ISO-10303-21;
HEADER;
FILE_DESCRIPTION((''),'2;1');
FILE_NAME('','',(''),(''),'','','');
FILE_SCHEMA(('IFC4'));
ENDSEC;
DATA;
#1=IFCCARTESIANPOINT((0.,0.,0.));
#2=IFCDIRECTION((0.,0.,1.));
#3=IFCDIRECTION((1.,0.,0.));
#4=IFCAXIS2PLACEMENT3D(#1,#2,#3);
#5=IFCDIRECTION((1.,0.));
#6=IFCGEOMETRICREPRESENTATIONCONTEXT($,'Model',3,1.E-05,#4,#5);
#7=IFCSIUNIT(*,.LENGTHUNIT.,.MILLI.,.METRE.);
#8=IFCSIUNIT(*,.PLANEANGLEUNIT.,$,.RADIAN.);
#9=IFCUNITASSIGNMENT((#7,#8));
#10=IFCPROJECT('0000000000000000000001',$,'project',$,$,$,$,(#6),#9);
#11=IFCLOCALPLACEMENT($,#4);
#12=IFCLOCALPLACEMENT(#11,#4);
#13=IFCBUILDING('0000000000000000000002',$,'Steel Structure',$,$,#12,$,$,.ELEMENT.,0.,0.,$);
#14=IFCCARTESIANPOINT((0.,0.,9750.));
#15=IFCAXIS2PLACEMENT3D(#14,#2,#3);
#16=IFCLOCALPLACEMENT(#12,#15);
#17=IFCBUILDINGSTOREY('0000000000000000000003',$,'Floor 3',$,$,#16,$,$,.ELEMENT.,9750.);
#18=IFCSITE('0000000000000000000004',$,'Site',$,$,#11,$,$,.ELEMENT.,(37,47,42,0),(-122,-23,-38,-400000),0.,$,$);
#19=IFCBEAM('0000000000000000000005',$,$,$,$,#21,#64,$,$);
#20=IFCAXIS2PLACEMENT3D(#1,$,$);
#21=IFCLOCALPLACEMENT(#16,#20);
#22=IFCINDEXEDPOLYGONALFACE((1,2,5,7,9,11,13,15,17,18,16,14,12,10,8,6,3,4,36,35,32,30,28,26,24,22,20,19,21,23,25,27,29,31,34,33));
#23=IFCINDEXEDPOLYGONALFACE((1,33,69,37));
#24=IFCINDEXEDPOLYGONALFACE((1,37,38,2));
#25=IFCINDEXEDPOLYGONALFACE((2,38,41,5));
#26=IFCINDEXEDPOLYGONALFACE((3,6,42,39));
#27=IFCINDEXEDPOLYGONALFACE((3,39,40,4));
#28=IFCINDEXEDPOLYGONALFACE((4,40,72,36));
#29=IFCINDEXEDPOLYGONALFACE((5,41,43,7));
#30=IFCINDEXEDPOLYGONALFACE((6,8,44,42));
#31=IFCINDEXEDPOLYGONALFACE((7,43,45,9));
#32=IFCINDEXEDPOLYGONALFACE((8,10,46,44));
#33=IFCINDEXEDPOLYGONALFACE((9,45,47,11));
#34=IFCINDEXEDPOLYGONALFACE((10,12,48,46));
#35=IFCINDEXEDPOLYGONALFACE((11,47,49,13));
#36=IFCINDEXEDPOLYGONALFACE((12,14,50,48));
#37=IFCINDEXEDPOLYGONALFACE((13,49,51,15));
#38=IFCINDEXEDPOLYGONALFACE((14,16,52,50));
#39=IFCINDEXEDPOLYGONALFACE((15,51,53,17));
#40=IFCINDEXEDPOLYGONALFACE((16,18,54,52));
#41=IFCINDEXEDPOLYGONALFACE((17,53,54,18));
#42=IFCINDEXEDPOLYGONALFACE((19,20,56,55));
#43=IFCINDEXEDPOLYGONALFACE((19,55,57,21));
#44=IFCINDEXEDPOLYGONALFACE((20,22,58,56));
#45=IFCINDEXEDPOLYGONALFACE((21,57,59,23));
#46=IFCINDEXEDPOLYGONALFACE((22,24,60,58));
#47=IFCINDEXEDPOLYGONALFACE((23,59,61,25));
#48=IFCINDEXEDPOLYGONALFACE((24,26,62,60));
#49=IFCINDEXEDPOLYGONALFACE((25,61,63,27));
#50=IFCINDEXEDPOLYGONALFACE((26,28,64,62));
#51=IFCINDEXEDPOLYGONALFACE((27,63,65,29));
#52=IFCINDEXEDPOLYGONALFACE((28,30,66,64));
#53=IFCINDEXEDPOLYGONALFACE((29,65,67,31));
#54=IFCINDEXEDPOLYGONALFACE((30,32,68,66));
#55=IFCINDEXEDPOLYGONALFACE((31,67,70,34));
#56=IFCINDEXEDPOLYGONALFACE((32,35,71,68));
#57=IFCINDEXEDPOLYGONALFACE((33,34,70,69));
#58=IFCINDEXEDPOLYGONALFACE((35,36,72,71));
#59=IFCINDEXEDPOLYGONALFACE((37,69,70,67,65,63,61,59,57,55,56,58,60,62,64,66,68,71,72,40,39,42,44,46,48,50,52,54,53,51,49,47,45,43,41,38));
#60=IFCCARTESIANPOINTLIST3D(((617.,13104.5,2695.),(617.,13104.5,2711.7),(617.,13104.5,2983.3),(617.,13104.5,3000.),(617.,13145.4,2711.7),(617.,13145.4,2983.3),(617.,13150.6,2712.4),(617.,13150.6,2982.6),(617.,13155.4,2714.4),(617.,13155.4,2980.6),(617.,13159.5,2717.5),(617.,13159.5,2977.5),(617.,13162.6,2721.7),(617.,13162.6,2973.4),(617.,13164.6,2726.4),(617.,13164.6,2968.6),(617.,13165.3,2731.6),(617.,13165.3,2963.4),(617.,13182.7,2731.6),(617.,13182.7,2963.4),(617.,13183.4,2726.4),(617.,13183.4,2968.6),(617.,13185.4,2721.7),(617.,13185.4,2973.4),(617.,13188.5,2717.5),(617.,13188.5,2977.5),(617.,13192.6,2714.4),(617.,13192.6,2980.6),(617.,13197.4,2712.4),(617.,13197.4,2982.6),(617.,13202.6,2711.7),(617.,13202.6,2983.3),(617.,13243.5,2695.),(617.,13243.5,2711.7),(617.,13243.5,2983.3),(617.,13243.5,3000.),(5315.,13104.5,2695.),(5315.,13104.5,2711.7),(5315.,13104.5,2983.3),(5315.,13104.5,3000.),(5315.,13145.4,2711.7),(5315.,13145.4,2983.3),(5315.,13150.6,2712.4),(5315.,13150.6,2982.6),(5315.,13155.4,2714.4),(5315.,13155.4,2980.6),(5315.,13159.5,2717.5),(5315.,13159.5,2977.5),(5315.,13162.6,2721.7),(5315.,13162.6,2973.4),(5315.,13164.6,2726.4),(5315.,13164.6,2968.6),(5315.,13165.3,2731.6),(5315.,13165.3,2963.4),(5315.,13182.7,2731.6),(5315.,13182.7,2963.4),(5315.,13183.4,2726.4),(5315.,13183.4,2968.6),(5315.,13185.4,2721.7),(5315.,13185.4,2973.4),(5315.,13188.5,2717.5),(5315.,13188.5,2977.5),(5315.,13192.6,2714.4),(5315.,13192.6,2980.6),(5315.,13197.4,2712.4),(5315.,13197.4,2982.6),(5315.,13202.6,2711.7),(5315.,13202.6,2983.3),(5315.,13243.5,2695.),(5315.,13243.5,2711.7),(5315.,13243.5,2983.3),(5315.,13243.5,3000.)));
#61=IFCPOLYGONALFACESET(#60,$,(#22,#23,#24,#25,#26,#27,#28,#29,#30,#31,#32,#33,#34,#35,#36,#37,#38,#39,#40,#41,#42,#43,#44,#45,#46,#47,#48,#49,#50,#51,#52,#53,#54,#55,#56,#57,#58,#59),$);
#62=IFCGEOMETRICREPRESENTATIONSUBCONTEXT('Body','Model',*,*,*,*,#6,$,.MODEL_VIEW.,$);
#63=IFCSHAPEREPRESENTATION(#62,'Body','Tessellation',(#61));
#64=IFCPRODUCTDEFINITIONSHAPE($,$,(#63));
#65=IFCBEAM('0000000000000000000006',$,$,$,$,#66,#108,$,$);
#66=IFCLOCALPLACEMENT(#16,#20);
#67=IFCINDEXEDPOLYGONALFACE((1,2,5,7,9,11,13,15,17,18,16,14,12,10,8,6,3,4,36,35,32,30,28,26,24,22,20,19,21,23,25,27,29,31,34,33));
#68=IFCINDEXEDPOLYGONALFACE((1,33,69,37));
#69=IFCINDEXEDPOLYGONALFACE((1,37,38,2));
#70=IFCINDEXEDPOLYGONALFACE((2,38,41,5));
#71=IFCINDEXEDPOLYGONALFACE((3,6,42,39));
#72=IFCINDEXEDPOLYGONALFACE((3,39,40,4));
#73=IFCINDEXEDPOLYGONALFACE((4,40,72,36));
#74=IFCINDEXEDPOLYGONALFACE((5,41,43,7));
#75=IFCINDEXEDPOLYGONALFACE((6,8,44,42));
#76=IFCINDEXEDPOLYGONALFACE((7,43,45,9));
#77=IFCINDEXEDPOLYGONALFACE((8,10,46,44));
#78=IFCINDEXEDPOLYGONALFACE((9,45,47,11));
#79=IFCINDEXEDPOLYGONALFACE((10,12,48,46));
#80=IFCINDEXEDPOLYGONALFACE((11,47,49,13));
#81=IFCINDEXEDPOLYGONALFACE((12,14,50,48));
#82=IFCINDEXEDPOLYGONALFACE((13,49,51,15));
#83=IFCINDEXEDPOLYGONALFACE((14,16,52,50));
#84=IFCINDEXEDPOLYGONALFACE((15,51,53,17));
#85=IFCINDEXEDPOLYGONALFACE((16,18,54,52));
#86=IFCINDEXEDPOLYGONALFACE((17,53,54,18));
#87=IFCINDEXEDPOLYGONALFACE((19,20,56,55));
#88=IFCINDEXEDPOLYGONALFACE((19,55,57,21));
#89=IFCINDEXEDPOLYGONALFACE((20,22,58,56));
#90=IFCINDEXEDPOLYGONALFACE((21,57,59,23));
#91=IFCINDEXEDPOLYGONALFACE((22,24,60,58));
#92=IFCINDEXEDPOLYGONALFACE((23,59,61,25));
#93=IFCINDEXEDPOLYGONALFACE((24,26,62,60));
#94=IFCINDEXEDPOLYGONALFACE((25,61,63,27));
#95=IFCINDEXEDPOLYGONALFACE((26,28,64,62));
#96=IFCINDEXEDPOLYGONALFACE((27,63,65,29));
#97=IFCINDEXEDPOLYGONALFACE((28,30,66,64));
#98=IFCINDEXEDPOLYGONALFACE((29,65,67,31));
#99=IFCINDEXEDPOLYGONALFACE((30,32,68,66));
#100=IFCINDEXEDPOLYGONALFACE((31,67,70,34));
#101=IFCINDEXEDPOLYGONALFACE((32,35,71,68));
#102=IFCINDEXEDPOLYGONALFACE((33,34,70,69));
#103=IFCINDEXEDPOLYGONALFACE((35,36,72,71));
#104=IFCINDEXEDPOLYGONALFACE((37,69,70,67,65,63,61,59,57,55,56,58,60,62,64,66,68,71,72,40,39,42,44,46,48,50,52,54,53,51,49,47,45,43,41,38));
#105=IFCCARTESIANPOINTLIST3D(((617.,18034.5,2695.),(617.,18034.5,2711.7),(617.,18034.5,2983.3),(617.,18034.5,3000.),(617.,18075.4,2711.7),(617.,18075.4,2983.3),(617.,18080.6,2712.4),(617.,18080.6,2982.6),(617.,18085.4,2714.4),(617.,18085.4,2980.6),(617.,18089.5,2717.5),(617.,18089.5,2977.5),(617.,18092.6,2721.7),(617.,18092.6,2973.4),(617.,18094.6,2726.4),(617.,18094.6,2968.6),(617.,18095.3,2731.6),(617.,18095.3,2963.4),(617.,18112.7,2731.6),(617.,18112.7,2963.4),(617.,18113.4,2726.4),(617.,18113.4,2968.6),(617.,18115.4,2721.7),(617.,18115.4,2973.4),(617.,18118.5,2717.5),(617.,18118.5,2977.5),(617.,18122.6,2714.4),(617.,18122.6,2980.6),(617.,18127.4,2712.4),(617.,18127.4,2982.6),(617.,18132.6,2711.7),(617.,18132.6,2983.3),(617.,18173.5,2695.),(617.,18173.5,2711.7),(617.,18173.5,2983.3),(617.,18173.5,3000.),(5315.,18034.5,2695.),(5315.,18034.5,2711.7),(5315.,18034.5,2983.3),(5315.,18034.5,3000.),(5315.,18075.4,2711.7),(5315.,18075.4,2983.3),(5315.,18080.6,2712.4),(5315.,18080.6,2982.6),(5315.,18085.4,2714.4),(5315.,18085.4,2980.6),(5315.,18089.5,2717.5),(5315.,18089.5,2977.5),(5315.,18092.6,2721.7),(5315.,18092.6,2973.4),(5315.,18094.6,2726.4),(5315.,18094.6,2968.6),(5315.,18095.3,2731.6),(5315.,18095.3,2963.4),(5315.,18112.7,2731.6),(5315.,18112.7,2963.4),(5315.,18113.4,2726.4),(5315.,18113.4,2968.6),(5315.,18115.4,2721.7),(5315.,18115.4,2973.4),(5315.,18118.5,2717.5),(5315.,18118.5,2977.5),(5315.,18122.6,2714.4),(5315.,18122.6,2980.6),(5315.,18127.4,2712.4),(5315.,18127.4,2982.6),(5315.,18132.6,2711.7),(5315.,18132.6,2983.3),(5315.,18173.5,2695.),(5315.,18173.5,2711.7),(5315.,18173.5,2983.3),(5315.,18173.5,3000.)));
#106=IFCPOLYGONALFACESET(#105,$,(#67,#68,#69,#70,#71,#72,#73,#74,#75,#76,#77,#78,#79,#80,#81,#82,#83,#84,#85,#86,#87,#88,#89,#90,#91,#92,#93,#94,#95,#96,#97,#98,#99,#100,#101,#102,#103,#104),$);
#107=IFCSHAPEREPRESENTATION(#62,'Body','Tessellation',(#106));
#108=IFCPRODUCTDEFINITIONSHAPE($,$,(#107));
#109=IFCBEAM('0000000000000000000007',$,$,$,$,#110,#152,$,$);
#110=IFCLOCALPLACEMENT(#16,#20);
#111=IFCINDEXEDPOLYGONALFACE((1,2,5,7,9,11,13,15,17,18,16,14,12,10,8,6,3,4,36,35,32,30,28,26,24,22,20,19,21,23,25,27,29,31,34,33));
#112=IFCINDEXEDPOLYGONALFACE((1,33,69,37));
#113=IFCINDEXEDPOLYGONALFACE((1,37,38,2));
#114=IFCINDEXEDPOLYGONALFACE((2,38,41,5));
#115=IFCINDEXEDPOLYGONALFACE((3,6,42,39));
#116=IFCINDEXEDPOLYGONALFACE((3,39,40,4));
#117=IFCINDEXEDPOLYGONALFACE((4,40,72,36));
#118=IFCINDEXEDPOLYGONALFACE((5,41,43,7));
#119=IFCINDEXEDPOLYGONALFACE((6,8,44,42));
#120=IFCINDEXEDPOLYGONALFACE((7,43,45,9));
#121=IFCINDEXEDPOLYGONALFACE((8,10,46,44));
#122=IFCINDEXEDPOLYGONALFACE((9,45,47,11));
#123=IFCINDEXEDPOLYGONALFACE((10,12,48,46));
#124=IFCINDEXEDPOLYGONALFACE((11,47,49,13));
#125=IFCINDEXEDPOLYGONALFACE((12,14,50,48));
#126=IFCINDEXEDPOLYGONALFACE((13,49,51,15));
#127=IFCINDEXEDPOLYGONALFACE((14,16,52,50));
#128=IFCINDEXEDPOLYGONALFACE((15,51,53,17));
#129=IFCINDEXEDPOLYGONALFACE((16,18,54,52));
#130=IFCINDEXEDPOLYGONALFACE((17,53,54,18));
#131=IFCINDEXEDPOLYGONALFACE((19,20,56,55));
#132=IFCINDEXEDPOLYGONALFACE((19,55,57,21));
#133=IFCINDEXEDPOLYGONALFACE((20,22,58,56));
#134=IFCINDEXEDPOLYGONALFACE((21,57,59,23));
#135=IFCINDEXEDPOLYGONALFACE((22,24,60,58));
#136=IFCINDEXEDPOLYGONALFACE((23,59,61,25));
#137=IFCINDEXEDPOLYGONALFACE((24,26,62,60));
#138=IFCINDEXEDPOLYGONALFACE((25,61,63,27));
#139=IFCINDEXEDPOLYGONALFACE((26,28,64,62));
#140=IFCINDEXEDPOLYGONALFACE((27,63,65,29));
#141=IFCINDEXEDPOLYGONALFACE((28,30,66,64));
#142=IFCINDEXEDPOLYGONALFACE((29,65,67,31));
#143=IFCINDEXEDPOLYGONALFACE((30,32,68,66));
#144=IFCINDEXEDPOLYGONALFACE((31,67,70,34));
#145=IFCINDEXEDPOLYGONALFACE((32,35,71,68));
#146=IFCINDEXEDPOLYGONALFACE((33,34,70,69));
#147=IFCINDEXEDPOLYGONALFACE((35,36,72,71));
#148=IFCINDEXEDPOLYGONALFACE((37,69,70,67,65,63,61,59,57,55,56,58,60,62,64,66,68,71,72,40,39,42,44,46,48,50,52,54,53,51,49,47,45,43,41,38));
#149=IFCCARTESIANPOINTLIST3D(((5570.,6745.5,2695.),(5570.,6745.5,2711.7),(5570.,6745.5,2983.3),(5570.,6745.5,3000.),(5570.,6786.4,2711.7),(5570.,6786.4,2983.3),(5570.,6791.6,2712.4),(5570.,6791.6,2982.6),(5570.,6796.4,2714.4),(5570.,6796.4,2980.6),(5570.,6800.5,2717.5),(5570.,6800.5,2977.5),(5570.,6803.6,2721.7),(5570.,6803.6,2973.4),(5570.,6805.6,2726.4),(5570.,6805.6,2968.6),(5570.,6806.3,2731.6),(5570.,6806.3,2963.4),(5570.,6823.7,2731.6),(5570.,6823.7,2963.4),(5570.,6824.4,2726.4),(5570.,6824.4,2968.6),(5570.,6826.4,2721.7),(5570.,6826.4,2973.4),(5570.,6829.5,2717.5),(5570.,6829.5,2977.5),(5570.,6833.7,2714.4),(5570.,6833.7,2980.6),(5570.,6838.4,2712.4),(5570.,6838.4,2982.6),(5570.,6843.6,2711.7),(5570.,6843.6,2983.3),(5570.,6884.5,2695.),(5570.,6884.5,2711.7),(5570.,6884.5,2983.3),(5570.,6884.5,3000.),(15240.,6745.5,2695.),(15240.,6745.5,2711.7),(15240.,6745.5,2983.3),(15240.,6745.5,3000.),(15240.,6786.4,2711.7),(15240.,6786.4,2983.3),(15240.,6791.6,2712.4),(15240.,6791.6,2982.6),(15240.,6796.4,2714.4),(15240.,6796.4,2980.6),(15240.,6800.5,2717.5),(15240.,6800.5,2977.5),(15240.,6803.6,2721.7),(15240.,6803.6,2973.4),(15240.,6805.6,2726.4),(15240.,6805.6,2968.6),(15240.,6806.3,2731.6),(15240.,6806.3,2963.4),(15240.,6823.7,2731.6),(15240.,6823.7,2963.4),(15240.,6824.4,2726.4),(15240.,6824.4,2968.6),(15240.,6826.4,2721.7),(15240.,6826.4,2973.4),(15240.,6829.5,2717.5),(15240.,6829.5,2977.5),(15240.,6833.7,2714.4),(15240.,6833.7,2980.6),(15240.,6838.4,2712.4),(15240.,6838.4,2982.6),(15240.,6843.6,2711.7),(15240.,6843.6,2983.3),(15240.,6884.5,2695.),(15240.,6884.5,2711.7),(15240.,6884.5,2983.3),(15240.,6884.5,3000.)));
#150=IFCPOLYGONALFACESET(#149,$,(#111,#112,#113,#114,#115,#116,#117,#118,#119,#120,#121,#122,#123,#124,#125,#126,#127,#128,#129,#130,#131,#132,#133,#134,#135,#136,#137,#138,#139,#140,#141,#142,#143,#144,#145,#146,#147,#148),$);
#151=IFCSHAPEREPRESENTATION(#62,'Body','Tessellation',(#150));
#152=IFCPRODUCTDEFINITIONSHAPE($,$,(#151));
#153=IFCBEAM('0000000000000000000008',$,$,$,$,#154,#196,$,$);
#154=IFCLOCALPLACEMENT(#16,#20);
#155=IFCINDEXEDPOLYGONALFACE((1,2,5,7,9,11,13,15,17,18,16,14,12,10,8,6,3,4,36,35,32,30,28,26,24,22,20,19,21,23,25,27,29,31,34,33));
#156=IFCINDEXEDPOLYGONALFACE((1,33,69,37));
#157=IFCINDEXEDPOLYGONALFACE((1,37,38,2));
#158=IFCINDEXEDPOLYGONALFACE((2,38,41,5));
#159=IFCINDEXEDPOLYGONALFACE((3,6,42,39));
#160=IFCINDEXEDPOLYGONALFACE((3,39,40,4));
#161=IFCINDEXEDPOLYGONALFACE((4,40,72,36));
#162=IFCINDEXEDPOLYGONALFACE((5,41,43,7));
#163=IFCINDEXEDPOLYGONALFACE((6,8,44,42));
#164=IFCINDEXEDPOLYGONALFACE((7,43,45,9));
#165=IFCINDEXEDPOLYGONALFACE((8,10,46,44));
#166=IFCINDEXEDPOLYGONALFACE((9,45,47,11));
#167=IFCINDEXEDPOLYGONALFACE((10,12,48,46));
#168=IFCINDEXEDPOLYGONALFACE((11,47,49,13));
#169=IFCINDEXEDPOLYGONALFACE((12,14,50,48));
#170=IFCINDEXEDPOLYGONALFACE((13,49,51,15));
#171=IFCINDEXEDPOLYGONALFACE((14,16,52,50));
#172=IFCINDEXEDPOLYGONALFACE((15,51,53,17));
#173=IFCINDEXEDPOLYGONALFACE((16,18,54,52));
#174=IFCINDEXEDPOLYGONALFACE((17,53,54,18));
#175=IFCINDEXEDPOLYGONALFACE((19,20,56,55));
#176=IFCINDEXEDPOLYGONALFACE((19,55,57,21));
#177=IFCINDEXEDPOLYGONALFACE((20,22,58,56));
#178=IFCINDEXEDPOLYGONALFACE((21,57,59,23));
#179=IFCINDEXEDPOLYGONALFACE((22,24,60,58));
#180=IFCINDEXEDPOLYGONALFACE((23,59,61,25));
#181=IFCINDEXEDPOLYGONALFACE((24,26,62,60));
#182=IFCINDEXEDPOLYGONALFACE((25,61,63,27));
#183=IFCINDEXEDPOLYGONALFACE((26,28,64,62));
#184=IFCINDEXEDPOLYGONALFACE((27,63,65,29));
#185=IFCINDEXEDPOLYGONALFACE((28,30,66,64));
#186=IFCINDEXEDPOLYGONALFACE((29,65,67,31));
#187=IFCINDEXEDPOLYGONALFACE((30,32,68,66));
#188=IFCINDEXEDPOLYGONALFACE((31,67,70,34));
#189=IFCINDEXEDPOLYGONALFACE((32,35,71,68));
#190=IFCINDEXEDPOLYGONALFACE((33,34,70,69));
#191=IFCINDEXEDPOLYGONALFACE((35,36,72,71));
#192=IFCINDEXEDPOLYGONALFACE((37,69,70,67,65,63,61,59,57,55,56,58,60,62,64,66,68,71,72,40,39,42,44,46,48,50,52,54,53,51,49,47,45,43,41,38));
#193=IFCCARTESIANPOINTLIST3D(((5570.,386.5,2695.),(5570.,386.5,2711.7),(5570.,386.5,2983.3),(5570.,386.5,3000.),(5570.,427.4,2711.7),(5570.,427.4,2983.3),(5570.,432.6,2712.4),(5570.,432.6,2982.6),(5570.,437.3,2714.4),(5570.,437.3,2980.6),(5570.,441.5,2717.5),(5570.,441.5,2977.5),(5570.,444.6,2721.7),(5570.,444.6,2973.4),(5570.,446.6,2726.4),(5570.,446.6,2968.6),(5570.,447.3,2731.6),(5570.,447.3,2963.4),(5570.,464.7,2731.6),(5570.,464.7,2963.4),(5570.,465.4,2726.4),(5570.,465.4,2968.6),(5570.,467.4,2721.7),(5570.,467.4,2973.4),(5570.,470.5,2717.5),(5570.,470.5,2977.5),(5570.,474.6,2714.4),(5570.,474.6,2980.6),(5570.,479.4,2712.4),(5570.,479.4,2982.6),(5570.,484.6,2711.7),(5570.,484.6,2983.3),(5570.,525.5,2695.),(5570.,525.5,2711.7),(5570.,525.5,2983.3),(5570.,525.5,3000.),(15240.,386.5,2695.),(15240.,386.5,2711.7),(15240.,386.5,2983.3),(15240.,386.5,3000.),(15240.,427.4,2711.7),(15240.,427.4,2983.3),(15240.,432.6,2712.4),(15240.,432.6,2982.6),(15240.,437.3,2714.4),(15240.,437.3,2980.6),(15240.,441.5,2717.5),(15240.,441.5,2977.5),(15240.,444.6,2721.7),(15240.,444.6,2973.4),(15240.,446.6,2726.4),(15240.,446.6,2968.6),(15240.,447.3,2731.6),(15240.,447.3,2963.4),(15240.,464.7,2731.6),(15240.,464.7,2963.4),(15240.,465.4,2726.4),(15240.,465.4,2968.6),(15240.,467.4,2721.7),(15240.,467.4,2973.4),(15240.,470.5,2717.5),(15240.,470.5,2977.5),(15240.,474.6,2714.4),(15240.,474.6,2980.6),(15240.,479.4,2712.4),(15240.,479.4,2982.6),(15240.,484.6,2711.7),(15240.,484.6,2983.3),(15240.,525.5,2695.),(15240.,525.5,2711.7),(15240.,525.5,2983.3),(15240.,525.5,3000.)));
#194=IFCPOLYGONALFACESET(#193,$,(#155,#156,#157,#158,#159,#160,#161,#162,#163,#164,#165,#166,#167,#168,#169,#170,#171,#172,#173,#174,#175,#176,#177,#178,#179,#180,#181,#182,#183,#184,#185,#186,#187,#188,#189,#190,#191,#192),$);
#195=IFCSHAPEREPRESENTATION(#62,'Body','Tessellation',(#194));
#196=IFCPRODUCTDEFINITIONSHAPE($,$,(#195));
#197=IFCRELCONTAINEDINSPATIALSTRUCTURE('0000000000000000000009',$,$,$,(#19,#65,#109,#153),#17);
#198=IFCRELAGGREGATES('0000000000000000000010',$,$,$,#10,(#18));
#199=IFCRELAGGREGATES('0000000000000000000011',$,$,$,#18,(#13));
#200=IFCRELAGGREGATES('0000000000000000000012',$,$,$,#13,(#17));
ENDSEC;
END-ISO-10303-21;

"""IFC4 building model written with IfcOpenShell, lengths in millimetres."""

from ifc_helpers import new_model, si_unit, direction, frame, origin_with_axes, origin_2d_with_axis, place, context, subcontext, project, spatial, i_section, extrude, element, save


model = new_model("IFC4")

# Units and contexts
model_context = context("Model", 3, precision=1e-05, world=origin_with_axes(), true_north=direction((1.0, 0.0)))
body_context = subcontext(model_context, "Body", "Model", "MODEL_VIEW")
ifc_project = project(units=[si_unit("LENGTHUNIT", "METRE", prefix="MILLI"), si_unit("PLANEANGLEUNIT", "RADIAN")], contexts=[model_context])

# Site, building, storey
site_placement = place(None, origin_with_axes())
site = spatial("IfcSite", under=ifc_project, at=site_placement, Name="Site", CompositionType="ELEMENT", RefLatitude=(37, 47, 42, 0), RefLongitude=(-122, -23, -38, -400000), RefElevation=0.0)
building_placement = place(site_placement, origin_with_axes())
building = spatial("IfcBuilding", under=site, at=building_placement, Name="Steel Structure", CompositionType="ELEMENT", ElevationOfRefHeight=0.0, ElevationOfTerrain=0.0)
storey_placement = place(building_placement, frame((0.0, 0.0, 9750.0), z_axis=(0.0, 0.0, 1.0), x_axis=(1.0, 0.0, 0.0)))
storey = spatial("IfcBuildingStorey", under=building, at=storey_placement, Name="Floor 3", CompositionType="ELEMENT", Elevation=9750.0)

# Beams
for number, where, z_axis, x_axis in (
    (1, (617.0, 13174.0, 2695.0), (1.0, 0.0, 0.0), (0.0, 1.0, 0.0)),
    (2, (5315.0, 18104.0, 2695.0), (-1.0, 0.0, 0.0), (0.0, -1.0, 0.0)),
):
    element("IfcBeam", number, at=place(storey_placement, frame(where, z_axis=z_axis, x_axis=x_axis)), inside=storey, context=body_context, shape_type="SweptSolid", body=[
        extrude(i_section(OverallWidth=139.0, OverallDepth=305.0, WebThickness=17.4, FlangeThickness=16.7, FilletRadius=19.9, at=origin_2d_with_axis()), frame((0.0, 152.5, 0.0), z_axis=(0.0, 0.0, 1.0), x_axis=(1.0, 0.0, 0.0)), (0.0, 0.0, 1.0), 4698.0),
    ])
for number, where, z_axis, x_axis in (
    (3, (15240.0, 6815.0, 2695.0), (-1.0, 0.0, 0.0), (0.0, -1.0, 0.0)),
    (4, (15240.0, 456.0, 2695.0), (-1.0, 0.0, 0.0), (0.0, -1.0, 0.0)),
):
    element("IfcBeam", number, at=place(storey_placement, frame(where, z_axis=z_axis, x_axis=x_axis)), inside=storey, context=body_context, shape_type="SweptSolid", body=[
        extrude(i_section(OverallWidth=139.0, OverallDepth=305.0, WebThickness=17.4, FlangeThickness=16.7, FilletRadius=19.9, at=origin_2d_with_axis()), frame((0.0, 152.5, 0.0), z_axis=(0.0, 0.0, 1.0), x_axis=(1.0, 0.0, 0.0)), (0.0, 0.0, 1.0), 9670.0),
    ])

save(model, "model.ifc")
